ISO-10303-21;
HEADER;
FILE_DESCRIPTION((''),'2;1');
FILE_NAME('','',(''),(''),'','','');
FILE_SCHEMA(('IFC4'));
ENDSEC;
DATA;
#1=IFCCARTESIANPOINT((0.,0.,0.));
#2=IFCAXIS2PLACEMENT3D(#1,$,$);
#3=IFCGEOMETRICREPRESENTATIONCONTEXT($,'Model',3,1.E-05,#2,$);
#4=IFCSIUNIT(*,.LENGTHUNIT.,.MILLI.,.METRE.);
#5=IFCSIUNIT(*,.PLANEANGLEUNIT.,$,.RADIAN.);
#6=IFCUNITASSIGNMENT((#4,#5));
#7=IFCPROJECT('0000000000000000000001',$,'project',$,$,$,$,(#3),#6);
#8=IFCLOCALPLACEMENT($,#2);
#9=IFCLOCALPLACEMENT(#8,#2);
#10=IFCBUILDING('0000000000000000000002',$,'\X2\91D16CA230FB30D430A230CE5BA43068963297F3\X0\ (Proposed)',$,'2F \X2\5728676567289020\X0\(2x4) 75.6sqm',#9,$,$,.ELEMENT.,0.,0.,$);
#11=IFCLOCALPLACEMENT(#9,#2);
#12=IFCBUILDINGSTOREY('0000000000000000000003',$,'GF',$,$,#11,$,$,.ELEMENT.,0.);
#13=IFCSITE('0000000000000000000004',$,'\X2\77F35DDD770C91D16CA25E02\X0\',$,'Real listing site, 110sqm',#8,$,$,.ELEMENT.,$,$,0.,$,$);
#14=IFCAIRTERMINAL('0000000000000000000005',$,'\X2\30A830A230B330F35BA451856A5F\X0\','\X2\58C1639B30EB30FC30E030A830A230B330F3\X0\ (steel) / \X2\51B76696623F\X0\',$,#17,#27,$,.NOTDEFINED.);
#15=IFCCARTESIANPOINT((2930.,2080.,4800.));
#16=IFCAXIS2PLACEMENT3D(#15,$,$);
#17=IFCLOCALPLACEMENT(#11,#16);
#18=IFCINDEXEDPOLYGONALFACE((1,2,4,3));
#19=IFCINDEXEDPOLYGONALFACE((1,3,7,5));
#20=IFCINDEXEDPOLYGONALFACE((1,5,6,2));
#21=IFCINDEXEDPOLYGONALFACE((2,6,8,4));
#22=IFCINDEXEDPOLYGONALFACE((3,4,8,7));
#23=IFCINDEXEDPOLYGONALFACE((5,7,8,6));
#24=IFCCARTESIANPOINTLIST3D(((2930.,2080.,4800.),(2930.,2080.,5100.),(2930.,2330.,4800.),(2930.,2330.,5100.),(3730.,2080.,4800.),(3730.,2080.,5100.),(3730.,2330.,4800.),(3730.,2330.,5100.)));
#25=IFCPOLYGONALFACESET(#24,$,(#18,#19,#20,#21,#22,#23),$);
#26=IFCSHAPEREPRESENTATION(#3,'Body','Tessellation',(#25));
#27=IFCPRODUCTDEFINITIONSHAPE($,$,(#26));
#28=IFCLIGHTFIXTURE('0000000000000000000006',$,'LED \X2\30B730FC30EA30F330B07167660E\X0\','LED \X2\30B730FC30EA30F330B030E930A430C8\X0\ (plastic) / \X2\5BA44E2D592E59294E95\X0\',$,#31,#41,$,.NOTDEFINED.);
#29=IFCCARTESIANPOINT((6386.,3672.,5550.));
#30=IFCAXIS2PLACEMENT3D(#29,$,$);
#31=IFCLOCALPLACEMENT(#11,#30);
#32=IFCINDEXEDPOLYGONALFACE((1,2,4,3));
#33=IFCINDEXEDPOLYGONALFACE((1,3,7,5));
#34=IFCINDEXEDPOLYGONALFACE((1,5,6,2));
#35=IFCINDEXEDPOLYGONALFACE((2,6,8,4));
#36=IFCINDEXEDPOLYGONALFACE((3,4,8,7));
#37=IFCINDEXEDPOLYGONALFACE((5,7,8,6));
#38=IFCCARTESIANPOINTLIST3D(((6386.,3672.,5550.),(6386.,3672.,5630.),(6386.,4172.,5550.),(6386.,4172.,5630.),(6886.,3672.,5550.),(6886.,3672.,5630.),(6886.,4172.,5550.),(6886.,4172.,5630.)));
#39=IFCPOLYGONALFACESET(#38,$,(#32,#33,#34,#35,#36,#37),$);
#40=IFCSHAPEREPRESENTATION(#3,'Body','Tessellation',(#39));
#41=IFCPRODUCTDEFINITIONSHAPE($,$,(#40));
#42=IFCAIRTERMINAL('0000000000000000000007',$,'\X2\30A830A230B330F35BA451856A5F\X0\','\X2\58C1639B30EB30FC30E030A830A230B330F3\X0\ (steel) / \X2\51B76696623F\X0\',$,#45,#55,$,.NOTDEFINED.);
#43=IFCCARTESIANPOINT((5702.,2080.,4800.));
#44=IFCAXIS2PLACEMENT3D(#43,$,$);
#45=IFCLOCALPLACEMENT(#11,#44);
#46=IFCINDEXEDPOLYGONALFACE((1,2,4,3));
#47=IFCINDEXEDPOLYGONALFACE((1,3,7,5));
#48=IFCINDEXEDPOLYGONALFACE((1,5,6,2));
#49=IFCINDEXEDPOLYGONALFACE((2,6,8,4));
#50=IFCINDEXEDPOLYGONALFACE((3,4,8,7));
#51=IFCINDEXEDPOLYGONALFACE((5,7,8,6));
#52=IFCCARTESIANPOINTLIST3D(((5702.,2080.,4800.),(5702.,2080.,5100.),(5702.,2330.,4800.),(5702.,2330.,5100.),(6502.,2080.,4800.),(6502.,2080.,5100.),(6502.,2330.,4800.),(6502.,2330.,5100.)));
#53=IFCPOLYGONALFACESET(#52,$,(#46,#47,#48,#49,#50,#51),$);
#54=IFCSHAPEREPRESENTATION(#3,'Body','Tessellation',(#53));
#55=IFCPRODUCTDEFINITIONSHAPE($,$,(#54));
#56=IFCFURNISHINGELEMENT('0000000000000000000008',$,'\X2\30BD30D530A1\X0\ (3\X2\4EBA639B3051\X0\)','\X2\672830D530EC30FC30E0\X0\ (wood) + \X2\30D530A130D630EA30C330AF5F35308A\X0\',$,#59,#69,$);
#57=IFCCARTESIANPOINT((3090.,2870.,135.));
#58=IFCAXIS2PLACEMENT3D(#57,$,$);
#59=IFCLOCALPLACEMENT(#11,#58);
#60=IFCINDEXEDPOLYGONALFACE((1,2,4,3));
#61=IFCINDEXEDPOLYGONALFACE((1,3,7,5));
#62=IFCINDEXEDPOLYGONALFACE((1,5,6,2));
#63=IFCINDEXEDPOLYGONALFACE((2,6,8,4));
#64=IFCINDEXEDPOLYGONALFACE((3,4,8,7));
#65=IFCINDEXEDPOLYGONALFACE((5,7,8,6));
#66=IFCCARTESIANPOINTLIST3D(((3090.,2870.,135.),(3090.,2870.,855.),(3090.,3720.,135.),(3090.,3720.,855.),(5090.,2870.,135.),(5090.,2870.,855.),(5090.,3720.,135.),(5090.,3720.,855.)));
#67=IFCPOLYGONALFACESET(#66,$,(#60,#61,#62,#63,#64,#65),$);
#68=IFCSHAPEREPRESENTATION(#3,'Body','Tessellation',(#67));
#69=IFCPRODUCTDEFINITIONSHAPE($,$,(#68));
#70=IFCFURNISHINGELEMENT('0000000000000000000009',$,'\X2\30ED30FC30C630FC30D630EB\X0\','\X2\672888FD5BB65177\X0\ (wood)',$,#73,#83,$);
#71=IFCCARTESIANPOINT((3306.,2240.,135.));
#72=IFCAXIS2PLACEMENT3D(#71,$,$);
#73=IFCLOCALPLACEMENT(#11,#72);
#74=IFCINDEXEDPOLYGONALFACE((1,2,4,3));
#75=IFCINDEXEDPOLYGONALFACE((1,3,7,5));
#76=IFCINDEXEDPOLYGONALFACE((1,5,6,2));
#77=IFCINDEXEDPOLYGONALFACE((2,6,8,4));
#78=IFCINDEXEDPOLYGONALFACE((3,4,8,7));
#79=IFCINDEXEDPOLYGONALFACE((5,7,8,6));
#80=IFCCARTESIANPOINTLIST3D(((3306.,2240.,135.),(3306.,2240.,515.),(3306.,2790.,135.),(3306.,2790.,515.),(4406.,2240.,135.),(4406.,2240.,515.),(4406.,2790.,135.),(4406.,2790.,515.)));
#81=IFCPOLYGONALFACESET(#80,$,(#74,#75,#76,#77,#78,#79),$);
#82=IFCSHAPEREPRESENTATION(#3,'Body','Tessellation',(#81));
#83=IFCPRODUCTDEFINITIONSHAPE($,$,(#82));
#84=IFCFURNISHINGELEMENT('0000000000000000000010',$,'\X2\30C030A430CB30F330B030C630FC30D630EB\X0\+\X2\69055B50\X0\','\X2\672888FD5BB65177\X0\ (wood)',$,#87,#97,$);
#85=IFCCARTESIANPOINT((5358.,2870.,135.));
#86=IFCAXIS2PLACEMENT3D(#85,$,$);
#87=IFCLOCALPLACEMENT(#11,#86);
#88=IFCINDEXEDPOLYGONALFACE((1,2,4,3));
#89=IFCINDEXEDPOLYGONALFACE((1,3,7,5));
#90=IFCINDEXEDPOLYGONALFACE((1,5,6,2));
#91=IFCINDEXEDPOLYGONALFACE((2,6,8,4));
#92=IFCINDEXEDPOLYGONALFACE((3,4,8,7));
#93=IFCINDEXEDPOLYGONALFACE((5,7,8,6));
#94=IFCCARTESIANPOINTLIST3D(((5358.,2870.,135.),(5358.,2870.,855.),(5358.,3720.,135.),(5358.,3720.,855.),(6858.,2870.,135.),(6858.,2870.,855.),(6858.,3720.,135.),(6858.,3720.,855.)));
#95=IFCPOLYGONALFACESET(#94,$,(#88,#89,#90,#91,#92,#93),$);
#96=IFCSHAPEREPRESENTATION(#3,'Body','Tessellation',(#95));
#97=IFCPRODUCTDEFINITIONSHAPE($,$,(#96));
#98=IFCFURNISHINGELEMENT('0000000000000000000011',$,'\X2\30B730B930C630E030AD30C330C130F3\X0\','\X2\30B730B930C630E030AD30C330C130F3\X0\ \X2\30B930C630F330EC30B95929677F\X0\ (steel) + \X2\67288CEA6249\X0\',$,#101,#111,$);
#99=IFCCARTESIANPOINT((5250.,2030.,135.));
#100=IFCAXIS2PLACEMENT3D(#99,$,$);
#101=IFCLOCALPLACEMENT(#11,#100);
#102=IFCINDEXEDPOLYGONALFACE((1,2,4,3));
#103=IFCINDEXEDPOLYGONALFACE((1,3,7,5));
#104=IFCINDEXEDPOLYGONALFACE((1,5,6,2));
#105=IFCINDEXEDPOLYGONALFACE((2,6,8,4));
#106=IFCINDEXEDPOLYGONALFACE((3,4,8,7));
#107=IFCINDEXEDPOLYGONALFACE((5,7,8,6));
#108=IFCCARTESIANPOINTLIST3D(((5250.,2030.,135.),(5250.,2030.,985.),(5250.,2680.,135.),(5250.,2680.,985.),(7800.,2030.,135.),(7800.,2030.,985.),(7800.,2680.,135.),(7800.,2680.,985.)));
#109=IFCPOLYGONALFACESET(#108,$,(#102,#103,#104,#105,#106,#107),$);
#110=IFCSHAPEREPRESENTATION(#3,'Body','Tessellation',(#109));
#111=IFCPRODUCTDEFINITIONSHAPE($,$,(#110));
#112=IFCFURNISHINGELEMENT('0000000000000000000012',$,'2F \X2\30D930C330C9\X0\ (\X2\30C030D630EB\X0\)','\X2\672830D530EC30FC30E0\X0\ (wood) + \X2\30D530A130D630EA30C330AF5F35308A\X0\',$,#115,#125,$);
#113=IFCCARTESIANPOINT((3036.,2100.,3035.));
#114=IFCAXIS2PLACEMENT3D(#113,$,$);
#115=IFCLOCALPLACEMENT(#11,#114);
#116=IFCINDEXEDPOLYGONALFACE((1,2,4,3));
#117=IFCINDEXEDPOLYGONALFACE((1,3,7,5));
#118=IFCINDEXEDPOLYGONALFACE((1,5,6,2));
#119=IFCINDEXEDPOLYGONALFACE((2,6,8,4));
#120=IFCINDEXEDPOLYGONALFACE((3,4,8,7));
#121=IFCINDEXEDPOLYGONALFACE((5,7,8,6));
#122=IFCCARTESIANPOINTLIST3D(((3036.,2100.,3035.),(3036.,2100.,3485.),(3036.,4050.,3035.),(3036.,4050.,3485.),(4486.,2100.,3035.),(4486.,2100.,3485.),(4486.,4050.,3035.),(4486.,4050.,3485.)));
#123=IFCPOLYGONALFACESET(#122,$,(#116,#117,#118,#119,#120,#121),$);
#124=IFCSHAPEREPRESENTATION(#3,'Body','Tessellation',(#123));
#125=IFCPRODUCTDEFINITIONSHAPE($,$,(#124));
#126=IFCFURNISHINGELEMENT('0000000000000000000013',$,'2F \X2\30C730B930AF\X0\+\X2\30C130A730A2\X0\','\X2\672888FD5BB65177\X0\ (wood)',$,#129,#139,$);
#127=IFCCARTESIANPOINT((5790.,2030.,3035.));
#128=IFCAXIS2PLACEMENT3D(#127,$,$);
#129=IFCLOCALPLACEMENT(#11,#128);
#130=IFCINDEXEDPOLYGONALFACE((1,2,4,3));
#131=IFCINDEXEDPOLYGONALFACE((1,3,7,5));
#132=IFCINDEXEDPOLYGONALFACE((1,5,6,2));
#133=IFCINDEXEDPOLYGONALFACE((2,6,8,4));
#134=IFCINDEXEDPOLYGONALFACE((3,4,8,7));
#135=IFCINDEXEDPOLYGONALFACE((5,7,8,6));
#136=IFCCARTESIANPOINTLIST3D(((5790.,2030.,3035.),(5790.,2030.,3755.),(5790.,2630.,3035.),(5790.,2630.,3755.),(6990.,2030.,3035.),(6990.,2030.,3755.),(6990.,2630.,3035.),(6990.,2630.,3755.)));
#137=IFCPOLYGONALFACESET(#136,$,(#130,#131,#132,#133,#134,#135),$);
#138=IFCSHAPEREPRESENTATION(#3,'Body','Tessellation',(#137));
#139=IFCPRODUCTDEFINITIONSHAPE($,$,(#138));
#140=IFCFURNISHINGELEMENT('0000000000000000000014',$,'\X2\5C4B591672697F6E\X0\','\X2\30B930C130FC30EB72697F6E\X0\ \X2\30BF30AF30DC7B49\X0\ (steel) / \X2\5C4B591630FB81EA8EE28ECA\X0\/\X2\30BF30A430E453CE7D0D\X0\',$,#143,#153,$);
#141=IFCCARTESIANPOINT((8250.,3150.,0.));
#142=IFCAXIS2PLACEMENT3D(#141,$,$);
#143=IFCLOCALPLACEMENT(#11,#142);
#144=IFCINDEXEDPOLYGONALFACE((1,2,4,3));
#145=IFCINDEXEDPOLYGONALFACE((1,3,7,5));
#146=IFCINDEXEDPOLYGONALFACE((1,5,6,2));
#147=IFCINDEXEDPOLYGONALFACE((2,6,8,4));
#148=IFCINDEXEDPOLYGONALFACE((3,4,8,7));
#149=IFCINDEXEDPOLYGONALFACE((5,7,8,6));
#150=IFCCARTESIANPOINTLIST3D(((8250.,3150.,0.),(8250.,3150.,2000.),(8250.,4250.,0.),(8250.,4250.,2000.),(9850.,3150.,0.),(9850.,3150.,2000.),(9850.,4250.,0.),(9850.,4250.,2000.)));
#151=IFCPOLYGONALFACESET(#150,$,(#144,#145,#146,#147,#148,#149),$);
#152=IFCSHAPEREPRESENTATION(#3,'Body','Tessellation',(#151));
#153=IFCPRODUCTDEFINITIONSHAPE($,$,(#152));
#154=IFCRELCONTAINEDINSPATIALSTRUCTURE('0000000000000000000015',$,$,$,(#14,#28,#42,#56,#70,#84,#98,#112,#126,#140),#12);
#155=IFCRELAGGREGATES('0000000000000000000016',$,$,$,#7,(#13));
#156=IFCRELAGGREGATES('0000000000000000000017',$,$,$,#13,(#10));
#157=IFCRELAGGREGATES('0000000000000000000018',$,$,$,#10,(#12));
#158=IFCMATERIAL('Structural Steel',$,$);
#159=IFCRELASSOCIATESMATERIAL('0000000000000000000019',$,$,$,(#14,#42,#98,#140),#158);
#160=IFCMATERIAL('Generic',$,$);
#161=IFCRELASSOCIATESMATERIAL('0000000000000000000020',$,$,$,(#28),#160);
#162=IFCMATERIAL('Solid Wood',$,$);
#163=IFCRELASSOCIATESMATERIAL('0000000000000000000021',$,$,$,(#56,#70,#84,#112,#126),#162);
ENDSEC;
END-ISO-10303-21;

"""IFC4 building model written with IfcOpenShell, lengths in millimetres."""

from ifc_helpers import new_model, si_unit, frame, frame_2d, origin, place, context, project, spatial, rectangle, extrude, material, element, save


model = new_model("IFC4")

# Units and contexts
model_context = context("Model", 3, precision=1e-05, world=origin())
ifc_project = project(units=[si_unit("LENGTHUNIT", "METRE", prefix="MILLI"), si_unit("PLANEANGLEUNIT", "RADIAN")], contexts=[model_context])

# Site, building, storey
site_placement = place(None, origin())
site = spatial("IfcSite", under=ifc_project, at=site_placement, Name="石川県金沢市", ObjectType="Real listing site, 110sqm", CompositionType="ELEMENT", RefElevation=0.0)
building_placement = place(site_placement, origin())
building = spatial("IfcBuilding", under=site, at=building_placement, Name="金沢・ピアノ室と防音 (Proposed)", ObjectType="2F 在来木造(2x4) 75.6sqm", CompositionType="ELEMENT", ElevationOfRefHeight=0.0, ElevationOfTerrain=0.0)
storey_placement = place(building_placement, origin())
storey = spatial("IfcBuildingStorey", under=building, at=storey_placement, Name="GF", CompositionType="ELEMENT", Elevation=0.0)

# Shared definitions
ifc_material_1 = material(Name="Solid Wood")

# Shared definitions
ifc_material_2 = material(Name="Generic")

# Shared definitions
ifc_material_3 = material(Name="Structural Steel")

# Air terminal
air_terminal_1_placement = place(storey_placement, frame((2930.0, 2080.0, 4800.0)))
element("IfcAirTerminal", 1, at=air_terminal_1_placement, inside=storey, material=ifc_material_3, Name="エアコン室内機", Description="壁掛ルームエアコン (steel) / 冷暖房", PredefinedType="NOTDEFINED", context=model_context, shape_type="SweptSolid", body=[
    extrude(rectangle(XDim=800.0, YDim=250.0, at=frame_2d((400.0, 125.0))), frame((2930.0, 2080.0, 4800.0)), (0.0, 0.0, 1.0), 300.0),
])

# Light fixture
light_fixture_placement = place(storey_placement, frame((6386.0, 3672.0, 5550.0)))
element("IfcLightFixture", 2, at=light_fixture_placement, inside=storey, material=ifc_material_2, Name="LED シーリング照明", Description="LED シーリングライト (plastic) / 室中央天井", PredefinedType="NOTDEFINED", context=model_context, shape_type="SweptSolid", body=[
    extrude(rectangle(XDim=500.0, YDim=500.0, at=frame_2d((250.0, 250.0))), frame((6386.0, 3672.0, 5550.0)), (0.0, 0.0, 1.0), 80.0),
])

# Air terminal
air_terminal_2_placement = place(storey_placement, frame((5702.0, 2080.0, 4800.0)))
element("IfcAirTerminal", 3, at=air_terminal_2_placement, inside=storey, material=ifc_material_3, Name="エアコン室内機", Description="壁掛ルームエアコン (steel) / 冷暖房", PredefinedType="NOTDEFINED", context=model_context, shape_type="SweptSolid", body=[
    extrude(rectangle(XDim=800.0, YDim=250.0, at=frame_2d((400.0, 125.0))), frame((5702.0, 2080.0, 4800.0)), (0.0, 0.0, 1.0), 300.0),
])

# Furnishing elements
furnishing_1_placement = place(storey_placement, frame((3090.0, 2870.0, 135.0)))
element("IfcFurnishingElement", 4, at=furnishing_1_placement, inside=storey, material=ifc_material_1, Name="ソファ (3人掛け)", Description="木フレーム (wood) + ファブリック張り", context=model_context, shape_type="SweptSolid", body=[
    extrude(rectangle(XDim=2000.0, YDim=850.0, at=frame_2d((1000.0, 425.0))), frame((3090.0, 2870.0, 135.0)), (0.0, 0.0, 1.0), 720.0),
])
furnishing_2_placement = place(storey_placement, frame((3306.0, 2240.0, 135.0)))
element("IfcFurnishingElement", 5, at=furnishing_2_placement, inside=storey, material=ifc_material_1, Name="ローテーブル", Description="木製家具 (wood)", context=model_context, shape_type="SweptSolid", body=[
    extrude(rectangle(XDim=1100.0, YDim=550.0, at=frame_2d((550.0, 275.0))), frame((3306.0, 2240.0, 135.0)), (0.0, 0.0, 1.0), 380.0),
])
furnishing_3_placement = place(storey_placement, frame((5358.0, 2870.0, 135.0)))
element("IfcFurnishingElement", 6, at=furnishing_3_placement, inside=storey, material=ifc_material_1, Name="ダイニングテーブル+椅子", Description="木製家具 (wood)", context=model_context, shape_type="SweptSolid", body=[
    extrude(rectangle(XDim=1500.0, YDim=850.0, at=frame_2d((750.0, 425.0))), frame((5358.0, 2870.0, 135.0)), (0.0, 0.0, 1.0), 720.0),
])
furnishing_4_placement = place(storey_placement, frame((5250.0, 2030.0, 135.0)))
element("IfcFurnishingElement", 7, at=furnishing_4_placement, inside=storey, material=ifc_material_3, Name="システムキッチン", Description="システムキッチン ステンレス天板 (steel) + 木質扉", context=model_context, shape_type="SweptSolid", body=[
    extrude(rectangle(XDim=2550.0, YDim=650.0, at=frame_2d((1275.0, 325.0))), frame((5250.0, 2030.0, 135.0)), (0.0, 0.0, 1.0), 850.0),
])
furnishing_5_placement = place(storey_placement, frame((3036.0, 2100.0, 3035.0)))
element("IfcFurnishingElement", 8, at=furnishing_5_placement, inside=storey, material=ifc_material_1, Name="2F ベッド (ダブル)", Description="木フレーム (wood) + ファブリック張り", context=model_context, shape_type="SweptSolid", body=[
    extrude(rectangle(XDim=1450.0, YDim=1950.0, at=frame_2d((725.0, 975.0))), frame((3036.0, 2100.0, 3035.0)), (0.0, 0.0, 1.0), 450.0),
])
furnishing_6_placement = place(storey_placement, frame((5790.0, 2030.0, 3035.0)))
element("IfcFurnishingElement", 9, at=furnishing_6_placement, inside=storey, material=ifc_material_1, Name="2F デスク+チェア", Description="木製家具 (wood)", context=model_context, shape_type="SweptSolid", body=[
    extrude(rectangle(XDim=1200.0, YDim=600.0, at=frame_2d((600.0, 300.0))), frame((5790.0, 2030.0, 3035.0)), (0.0, 0.0, 1.0), 720.0),
])
furnishing_7_placement = place(storey_placement, frame((8250.0, 3150.0, 0.0)))
element("IfcFurnishingElement", 10, at=furnishing_7_placement, inside=storey, material=ifc_material_3, Name="屋外物置", Description="スチール物置 タクボ等 (steel) / 屋外・自転車/タイヤ収納", context=model_context, shape_type="SweptSolid", body=[
    extrude(rectangle(XDim=1600.0, YDim=1100.0, at=frame_2d((800.0, 550.0))), frame((8250.0, 3150.0, 0.0)), (0.0, 0.0, 1.0), 2000.0),
])

save(model, "model.ifc")
